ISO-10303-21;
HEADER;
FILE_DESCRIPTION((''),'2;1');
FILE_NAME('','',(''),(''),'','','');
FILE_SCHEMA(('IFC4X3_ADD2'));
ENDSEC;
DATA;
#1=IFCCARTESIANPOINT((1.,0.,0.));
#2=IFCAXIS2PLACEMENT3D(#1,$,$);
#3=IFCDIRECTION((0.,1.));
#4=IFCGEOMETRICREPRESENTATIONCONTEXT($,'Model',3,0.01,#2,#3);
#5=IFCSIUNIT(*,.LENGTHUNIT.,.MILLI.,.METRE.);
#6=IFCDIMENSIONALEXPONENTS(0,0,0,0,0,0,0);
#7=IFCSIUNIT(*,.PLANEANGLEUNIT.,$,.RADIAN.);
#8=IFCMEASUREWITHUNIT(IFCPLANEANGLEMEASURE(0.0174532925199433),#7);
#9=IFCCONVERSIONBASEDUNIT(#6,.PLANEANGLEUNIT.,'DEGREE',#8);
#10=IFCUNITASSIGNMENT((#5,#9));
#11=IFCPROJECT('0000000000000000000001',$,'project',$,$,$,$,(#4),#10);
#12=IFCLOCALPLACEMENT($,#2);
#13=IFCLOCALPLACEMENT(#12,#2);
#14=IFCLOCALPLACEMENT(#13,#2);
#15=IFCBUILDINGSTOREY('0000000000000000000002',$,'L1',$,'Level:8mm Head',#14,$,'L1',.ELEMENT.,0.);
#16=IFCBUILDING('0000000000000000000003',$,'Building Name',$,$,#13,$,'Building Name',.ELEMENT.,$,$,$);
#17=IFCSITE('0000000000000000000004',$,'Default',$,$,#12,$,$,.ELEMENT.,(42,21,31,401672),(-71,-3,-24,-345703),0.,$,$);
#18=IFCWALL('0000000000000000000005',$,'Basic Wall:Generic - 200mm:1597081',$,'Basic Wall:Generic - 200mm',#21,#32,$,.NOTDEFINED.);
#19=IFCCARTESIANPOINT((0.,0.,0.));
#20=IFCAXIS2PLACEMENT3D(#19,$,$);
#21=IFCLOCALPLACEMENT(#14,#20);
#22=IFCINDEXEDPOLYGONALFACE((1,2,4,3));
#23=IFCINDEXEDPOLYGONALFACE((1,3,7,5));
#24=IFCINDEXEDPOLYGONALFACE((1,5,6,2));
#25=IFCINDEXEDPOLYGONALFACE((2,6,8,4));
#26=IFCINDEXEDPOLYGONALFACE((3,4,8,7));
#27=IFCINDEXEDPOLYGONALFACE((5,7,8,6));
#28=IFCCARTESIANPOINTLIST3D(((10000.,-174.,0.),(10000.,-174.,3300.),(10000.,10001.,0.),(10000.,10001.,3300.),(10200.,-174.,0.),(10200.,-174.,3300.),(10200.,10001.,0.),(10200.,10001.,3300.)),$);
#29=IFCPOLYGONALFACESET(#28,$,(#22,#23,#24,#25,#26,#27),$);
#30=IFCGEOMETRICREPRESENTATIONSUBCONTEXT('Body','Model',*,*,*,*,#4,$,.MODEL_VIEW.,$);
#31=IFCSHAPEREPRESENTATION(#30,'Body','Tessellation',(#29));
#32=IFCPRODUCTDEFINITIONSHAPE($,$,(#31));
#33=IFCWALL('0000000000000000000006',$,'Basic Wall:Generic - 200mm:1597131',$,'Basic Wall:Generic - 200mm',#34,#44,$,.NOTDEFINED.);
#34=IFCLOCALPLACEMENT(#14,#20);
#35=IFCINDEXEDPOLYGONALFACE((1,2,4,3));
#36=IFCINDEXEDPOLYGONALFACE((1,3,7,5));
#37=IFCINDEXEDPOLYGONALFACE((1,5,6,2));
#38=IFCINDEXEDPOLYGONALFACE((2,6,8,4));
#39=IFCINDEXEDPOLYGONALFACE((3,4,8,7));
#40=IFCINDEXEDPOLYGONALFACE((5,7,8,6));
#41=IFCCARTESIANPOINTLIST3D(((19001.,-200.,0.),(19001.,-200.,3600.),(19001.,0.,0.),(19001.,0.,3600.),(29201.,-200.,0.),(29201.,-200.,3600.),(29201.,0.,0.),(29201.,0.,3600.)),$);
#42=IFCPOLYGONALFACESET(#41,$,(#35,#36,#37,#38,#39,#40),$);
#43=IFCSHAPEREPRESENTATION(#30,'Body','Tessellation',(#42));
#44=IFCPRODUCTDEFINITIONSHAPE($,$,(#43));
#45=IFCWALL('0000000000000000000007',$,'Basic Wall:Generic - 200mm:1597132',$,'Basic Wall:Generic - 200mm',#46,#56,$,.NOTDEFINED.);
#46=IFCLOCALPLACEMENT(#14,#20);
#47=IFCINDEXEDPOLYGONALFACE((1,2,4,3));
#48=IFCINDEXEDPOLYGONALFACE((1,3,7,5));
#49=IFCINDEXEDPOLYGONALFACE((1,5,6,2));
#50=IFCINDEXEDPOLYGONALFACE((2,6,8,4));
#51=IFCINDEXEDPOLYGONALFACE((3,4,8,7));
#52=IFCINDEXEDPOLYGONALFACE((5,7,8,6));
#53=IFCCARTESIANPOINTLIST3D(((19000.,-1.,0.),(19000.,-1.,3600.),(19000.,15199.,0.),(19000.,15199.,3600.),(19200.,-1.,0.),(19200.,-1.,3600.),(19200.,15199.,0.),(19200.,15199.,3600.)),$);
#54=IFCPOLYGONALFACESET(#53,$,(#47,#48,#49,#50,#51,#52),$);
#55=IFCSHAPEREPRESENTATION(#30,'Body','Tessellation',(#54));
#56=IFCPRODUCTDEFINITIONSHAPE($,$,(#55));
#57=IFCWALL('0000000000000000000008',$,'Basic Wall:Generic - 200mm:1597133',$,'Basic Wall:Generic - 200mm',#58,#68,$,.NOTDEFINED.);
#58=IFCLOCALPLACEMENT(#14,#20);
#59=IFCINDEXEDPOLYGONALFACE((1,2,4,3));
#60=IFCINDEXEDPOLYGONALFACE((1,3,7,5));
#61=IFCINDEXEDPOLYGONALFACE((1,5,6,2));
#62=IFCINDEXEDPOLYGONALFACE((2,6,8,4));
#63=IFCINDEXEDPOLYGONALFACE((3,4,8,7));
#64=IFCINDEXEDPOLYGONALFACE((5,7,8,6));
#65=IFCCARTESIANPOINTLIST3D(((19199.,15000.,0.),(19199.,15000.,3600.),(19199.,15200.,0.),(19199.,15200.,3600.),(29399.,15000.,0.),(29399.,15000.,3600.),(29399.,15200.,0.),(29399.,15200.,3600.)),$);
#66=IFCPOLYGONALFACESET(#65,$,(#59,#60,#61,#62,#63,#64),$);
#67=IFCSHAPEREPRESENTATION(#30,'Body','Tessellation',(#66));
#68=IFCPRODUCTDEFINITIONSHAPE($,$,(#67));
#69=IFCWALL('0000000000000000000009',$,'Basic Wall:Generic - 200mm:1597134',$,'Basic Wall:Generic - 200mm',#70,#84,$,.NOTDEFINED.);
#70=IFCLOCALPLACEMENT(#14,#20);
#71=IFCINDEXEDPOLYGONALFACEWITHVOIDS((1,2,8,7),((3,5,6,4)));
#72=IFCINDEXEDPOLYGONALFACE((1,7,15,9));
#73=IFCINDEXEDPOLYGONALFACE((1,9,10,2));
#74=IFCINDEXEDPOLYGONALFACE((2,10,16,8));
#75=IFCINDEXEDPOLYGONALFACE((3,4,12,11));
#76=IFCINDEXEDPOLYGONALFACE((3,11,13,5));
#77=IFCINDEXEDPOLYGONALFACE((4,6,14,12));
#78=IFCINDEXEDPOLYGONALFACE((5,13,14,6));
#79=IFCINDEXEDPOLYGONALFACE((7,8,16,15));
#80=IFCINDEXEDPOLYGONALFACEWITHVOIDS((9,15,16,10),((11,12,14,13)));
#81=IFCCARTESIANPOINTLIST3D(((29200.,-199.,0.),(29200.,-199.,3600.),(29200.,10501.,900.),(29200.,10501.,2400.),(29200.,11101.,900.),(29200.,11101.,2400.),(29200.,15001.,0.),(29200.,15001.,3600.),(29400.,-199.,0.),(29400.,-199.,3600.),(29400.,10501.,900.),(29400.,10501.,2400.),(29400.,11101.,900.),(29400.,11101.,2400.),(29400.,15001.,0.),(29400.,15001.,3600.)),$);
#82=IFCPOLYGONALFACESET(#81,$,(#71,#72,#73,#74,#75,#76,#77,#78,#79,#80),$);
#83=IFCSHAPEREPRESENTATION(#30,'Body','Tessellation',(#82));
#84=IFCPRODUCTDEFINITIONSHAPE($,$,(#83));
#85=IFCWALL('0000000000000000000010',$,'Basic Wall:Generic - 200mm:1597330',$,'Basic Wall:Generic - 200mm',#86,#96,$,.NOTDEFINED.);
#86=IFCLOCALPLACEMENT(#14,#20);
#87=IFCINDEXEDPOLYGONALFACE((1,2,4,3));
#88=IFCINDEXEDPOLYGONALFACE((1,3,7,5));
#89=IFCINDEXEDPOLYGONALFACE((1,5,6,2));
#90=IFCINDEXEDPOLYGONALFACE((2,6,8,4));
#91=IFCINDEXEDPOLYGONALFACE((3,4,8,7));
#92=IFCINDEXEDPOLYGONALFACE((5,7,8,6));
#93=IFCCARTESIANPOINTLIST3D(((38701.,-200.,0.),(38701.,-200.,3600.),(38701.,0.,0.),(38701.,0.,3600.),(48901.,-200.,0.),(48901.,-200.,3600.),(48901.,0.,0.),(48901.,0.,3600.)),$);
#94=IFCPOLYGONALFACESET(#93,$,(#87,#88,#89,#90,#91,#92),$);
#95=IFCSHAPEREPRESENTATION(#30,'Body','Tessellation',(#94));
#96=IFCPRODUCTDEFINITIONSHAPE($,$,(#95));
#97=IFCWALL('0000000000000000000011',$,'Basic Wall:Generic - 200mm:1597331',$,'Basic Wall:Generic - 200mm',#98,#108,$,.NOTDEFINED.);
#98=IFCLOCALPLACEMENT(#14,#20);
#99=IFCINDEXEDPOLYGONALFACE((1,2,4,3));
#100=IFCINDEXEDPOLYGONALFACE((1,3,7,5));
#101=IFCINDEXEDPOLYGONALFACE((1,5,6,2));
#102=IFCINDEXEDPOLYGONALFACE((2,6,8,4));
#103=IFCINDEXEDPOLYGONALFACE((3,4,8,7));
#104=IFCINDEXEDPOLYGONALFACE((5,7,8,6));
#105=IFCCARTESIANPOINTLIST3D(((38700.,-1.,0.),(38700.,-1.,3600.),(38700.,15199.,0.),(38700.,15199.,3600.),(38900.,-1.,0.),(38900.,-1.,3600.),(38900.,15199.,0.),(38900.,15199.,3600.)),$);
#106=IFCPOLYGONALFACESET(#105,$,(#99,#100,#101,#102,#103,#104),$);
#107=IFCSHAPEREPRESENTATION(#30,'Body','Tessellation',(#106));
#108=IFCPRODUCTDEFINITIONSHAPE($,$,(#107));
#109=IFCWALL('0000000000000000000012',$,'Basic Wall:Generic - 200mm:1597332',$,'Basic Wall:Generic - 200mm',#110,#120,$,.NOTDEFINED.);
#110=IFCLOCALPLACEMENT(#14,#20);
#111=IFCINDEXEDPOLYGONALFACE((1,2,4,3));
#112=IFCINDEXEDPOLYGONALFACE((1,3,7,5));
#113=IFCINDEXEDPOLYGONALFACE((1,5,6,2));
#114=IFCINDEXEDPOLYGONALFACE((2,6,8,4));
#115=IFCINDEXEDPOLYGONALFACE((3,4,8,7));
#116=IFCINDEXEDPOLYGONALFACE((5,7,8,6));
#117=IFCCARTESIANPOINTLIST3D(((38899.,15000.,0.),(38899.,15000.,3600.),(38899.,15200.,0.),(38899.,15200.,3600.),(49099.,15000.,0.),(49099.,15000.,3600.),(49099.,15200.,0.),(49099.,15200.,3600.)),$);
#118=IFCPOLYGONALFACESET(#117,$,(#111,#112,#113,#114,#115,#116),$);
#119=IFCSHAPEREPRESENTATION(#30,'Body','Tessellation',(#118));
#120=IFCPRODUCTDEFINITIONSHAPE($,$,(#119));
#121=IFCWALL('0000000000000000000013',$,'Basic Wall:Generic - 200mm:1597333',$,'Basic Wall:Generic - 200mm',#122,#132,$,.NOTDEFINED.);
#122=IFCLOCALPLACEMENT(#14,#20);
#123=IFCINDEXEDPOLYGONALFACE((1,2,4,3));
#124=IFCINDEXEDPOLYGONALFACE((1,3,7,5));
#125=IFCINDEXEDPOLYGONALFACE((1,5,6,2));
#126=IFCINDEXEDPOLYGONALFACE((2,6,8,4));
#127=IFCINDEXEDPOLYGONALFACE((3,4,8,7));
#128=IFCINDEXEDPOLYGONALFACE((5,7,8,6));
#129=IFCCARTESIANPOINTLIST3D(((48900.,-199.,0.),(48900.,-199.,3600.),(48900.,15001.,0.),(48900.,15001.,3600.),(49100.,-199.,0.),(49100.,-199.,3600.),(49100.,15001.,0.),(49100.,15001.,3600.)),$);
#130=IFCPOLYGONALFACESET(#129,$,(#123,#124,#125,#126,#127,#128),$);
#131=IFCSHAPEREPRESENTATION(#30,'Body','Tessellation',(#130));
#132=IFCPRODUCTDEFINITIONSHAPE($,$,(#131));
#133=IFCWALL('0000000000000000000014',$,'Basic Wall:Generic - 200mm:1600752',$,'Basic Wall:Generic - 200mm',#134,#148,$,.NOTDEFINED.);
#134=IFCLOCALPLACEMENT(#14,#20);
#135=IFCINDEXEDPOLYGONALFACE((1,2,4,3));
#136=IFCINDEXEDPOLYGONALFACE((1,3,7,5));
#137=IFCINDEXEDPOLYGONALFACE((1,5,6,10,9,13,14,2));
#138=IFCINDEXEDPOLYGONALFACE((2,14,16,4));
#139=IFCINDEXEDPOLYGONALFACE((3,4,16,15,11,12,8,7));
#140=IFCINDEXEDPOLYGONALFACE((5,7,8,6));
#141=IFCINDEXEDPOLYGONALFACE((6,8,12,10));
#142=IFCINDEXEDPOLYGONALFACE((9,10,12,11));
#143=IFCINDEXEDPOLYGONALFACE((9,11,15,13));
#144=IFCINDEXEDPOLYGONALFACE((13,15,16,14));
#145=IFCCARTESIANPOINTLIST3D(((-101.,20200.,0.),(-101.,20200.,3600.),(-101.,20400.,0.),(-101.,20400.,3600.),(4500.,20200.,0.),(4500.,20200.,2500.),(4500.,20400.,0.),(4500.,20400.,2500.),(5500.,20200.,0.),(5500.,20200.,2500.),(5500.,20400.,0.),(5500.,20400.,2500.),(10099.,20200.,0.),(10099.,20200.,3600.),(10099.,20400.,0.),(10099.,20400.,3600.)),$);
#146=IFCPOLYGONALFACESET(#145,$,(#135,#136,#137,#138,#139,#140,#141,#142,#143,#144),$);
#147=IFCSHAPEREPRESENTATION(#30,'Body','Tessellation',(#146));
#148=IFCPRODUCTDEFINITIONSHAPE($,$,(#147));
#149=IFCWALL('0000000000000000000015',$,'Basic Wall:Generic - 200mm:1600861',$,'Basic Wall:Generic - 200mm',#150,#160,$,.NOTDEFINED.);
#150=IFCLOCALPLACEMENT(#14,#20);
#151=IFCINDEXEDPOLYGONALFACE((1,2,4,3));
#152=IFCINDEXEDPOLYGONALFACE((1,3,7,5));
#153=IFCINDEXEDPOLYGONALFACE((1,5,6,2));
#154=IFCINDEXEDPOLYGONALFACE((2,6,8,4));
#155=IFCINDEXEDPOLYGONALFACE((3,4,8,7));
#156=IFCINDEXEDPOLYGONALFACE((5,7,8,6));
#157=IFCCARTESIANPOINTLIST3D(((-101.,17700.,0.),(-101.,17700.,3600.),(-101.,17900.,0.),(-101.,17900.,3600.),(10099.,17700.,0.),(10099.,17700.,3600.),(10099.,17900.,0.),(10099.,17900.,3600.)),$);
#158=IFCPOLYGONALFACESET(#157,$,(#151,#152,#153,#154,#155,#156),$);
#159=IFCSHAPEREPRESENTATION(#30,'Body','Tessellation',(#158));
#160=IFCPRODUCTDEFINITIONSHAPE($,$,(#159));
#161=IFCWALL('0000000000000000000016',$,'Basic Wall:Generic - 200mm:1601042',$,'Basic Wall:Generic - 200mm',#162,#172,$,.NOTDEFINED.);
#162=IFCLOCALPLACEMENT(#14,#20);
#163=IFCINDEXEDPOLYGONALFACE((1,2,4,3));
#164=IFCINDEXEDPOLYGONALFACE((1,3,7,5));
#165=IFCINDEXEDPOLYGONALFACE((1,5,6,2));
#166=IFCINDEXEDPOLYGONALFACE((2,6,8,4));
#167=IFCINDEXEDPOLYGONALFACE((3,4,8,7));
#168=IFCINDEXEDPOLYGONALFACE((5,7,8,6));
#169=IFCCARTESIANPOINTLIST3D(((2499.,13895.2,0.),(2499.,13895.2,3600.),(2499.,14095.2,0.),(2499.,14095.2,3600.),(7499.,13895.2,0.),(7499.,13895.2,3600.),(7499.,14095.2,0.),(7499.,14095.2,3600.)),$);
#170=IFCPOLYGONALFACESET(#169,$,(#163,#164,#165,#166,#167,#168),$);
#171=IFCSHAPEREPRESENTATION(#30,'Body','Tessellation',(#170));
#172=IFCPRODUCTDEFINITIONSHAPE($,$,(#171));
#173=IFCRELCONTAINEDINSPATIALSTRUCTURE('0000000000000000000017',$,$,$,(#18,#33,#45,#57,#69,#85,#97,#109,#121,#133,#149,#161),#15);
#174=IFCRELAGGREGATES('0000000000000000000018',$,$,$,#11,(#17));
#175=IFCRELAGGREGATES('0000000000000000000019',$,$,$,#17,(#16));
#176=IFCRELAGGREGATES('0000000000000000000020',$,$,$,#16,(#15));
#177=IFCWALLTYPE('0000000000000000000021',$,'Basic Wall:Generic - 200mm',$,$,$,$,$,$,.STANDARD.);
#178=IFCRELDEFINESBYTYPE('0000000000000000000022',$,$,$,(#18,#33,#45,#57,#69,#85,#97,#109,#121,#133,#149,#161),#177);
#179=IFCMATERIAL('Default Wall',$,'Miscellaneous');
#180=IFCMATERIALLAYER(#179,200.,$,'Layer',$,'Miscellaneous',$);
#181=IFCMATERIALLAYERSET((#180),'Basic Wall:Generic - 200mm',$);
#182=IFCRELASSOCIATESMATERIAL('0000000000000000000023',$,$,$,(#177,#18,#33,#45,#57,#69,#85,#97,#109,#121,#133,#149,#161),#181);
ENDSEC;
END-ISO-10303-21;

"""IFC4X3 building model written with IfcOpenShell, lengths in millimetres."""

from ifc_helpers import new_model, entity, si_unit, converted_unit, direction, frame, frame_2d, origin_2d_with_axis, place, context, subcontext, project, spatial, rectangle, extrude, material, layer, layer_set, type_object, element, save


model = new_model("IFC4X3")

# Units and contexts
model_context = context("Model", 3, precision=0.01, world=frame((1.0, 0.0, 0.0)), true_north=direction((0.0, 1.0)))
body_context = subcontext(model_context, "Body", "Model", "MODEL_VIEW")
ifc_project = project(units=[si_unit("LENGTHUNIT", "METRE", prefix="MILLI"), converted_unit("PLANEANGLEUNIT", "DEGREE", entity("IfcPlaneAngleMeasure", 0.0174532925199433), si_unit("PLANEANGLEUNIT", "RADIAN"), dimensions=[0, 0, 0, 0, 0, 0, 0])], contexts=[model_context])

# Site, building, storey
site_placement = place(None, frame((1.0, 0.0, 0.0)))
site = spatial("IfcSite", under=ifc_project, at=site_placement, Name="Default", CompositionType="ELEMENT", RefLatitude=(42, 21, 31, 401672), RefLongitude=(-71, -3, -24, -345703), RefElevation=0.0)
building_placement = place(site_placement, frame((1.0, 0.0, 0.0)))
building = spatial("IfcBuilding", under=site, at=building_placement, Name="Building Name", LongName="Building Name", CompositionType="ELEMENT")
storey_placement = place(building_placement, frame((1.0, 0.0, 0.0)))
storey = spatial("IfcBuildingStorey", under=building, at=storey_placement, Name="L1", ObjectType="Level:8mm Head", LongName="L1", CompositionType="ELEMENT", Elevation=0.0)

# Walls
ifc_material_1 = material(Name="Default Wall", Category="Miscellaneous")
ifc_layer_1 = layer(ifc_material_1, 200.0, Name="Layer", Category="Miscellaneous")
ifc_layer_set_1 = layer_set([ifc_layer_1], Name="Basic Wall:Generic - 200mm")
wall_type_1 = type_object("IfcWallType", Name="Basic Wall:Generic - 200mm", PredefinedType="STANDARD", material=ifc_layer_set_1)
wall_1_placement = place(storey_placement, frame((10100.0, -175.0, 0.0), z_axis=(0.0, 0.0, 1.0), x_axis=(0.0, 1.0, 0.0)))
element("IfcWall", 1, at=wall_1_placement, inside=storey, type_object=wall_type_1, material=ifc_layer_set_1, Name="Basic Wall:Generic - 200mm:1597081", ObjectType="Basic Wall:Generic - 200mm", PredefinedType="NOTDEFINED", context=body_context, shape_type="SweptSolid", body=[
    extrude(rectangle(XDim=10175.0, YDim=200.0, at=frame_2d((5087.5, 0.0), x_axis=(-1.0, 0.0))), frame((1.0, 0.0, 0.0)), (0.0, 0.0, 1.0), 3300.0),
])
wall_2_placement = place(storey_placement, frame((19000.0, -100.0, 0.0)))
element("IfcWall", 2, at=wall_2_placement, inside=storey, type_object=wall_type_1, material=ifc_layer_set_1, Name="Basic Wall:Generic - 200mm:1597131", ObjectType="Basic Wall:Generic - 200mm", PredefinedType="NOTDEFINED", context=body_context, shape_type="SweptSolid", body=[
    extrude(rectangle(XDim=10200.0, YDim=200.0, at=frame_2d((5100.0, 0.0), x_axis=(-1.0, 0.0))), frame((1.0, 0.0, 0.0)), (0.0, 0.0, 1.0), 3600.0),
])
wall_3_placement = place(storey_placement, frame((19100.0, 15200.0, 0.0), z_axis=(0.0, 0.0, 1.0), x_axis=(0.0, -1.0, 0.0)))
element("IfcWall", 3, at=wall_3_placement, inside=storey, type_object=wall_type_1, material=ifc_layer_set_1, Name="Basic Wall:Generic - 200mm:1597132", ObjectType="Basic Wall:Generic - 200mm", PredefinedType="NOTDEFINED", context=body_context, shape_type="SweptSolid", body=[
    extrude(rectangle(XDim=15200.0, YDim=200.0, at=frame_2d((7600.0, 0.0), x_axis=(-1.0, 0.0))), frame((1.0, 0.0, 0.0)), (0.0, 0.0, 1.0), 3600.0),
])
wall_4_placement = place(storey_placement, frame((29400.0, 15100.0, 0.0), z_axis=(0.0, 0.0, 1.0), x_axis=(-1.0, 0.0, 0.0)))
element("IfcWall", 4, at=wall_4_placement, inside=storey, type_object=wall_type_1, material=ifc_layer_set_1, Name="Basic Wall:Generic - 200mm:1597133", ObjectType="Basic Wall:Generic - 200mm", PredefinedType="NOTDEFINED", context=body_context, shape_type="SweptSolid", body=[
    extrude(rectangle(XDim=10200.0, YDim=200.0, at=frame_2d((5100.0, 0.0), x_axis=(-1.0, 0.0))), frame((1.0, 0.0, 0.0)), (0.0, 0.0, 1.0), 3600.0),
])

# Wall, opening
wall_5_placement = place(storey_placement, frame((29300.0, -200.0, 0.0), z_axis=(0.0, 0.0, 1.0), x_axis=(0.0, 1.0, 0.0)))
wall_5 = element("IfcWall", 5, at=wall_5_placement, inside=storey, type_object=wall_type_1, material=ifc_layer_set_1, Name="Basic Wall:Generic - 200mm:1597134", ObjectType="Basic Wall:Generic - 200mm", PredefinedType="NOTDEFINED", context=body_context, shape_type="SweptSolid", body=[
    extrude(rectangle(XDim=15200.0, YDim=200.0, at=frame_2d((7600.0, 0.0), x_axis=(-1.0, 0.0))), frame((1.0, 0.0, 0.0)), (0.0, 0.0, 1.0), 3600.0),
])
opening_1_placement = place(wall_5_placement, frame((11300.0, 100.0, 900.0)))
element("IfcOpeningElement", 6, at=opening_1_placement, cuts=wall_5, PredefinedType="OPENING", context=body_context, shape_type="SweptSolid", body=[
    extrude(rectangle(XDim=1500.0, YDim=600.0, at=frame_2d((750.0, 300.0), x_axis=(-1.0, 0.0))), frame((1.0, 0.0, 0.0), z_axis=(0.0, -1.0, 0.0), x_axis=(0.0, 0.0, 1.0)), (0.0, 0.0, 1.0), 200.0),
])

# Walls
wall_6_placement = place(storey_placement, frame((38700.0, -100.0, 0.0)))
element("IfcWall", 7, at=wall_6_placement, inside=storey, type_object=wall_type_1, material=ifc_layer_set_1, Name="Basic Wall:Generic - 200mm:1597330", ObjectType="Basic Wall:Generic - 200mm", PredefinedType="NOTDEFINED", context=body_context, shape_type="SweptSolid", body=[
    extrude(rectangle(XDim=10200.0, YDim=200.0, at=frame_2d((5100.0, 0.0), x_axis=(-1.0, 0.0))), frame((1.0, 0.0, 0.0)), (0.0, 0.0, 1.0), 3600.0),
])
wall_7_placement = place(storey_placement, frame((38800.0, 15200.0, 0.0), z_axis=(0.0, 0.0, 1.0), x_axis=(0.0, -1.0, 0.0)))
element("IfcWall", 8, at=wall_7_placement, inside=storey, type_object=wall_type_1, material=ifc_layer_set_1, Name="Basic Wall:Generic - 200mm:1597331", ObjectType="Basic Wall:Generic - 200mm", PredefinedType="NOTDEFINED", context=body_context, shape_type="SweptSolid", body=[
    extrude(rectangle(XDim=15200.0, YDim=200.0, at=frame_2d((7600.0, 0.0), x_axis=(-1.0, 0.0))), frame((1.0, 0.0, 0.0)), (0.0, 0.0, 1.0), 3600.0),
])
wall_8_placement = place(storey_placement, frame((49100.0, 15100.0, 0.0), z_axis=(0.0, 0.0, 1.0), x_axis=(-1.0, 0.0, 0.0)))
element("IfcWall", 9, at=wall_8_placement, inside=storey, type_object=wall_type_1, material=ifc_layer_set_1, Name="Basic Wall:Generic - 200mm:1597332", ObjectType="Basic Wall:Generic - 200mm", PredefinedType="NOTDEFINED", context=body_context, shape_type="SweptSolid", body=[
    extrude(rectangle(XDim=10200.0, YDim=200.0, at=frame_2d((5100.0, 0.0), x_axis=(-1.0, 0.0))), frame((1.0, 0.0, 0.0)), (0.0, 0.0, 1.0), 3600.0),
])
wall_9_placement = place(storey_placement, frame((49000.0, -200.0, 0.0), z_axis=(0.0, 0.0, 1.0), x_axis=(0.0, 1.0, 0.0)))
element("IfcWall", 10, at=wall_9_placement, inside=storey, type_object=wall_type_1, material=ifc_layer_set_1, Name="Basic Wall:Generic - 200mm:1597333", ObjectType="Basic Wall:Generic - 200mm", PredefinedType="NOTDEFINED", context=body_context, shape_type="SweptSolid", body=[
    extrude(rectangle(XDim=15200.0, YDim=200.0, at=frame_2d((7600.0, 0.0), x_axis=(-1.0, 0.0))), frame((1.0, 0.0, 0.0)), (0.0, 0.0, 1.0), 3600.0),
])

# Wall, opening
wall_10_placement = place(storey_placement, frame((10100.0, 20300.0, 0.0), z_axis=(0.0, 0.0, 1.0), x_axis=(-1.0, 0.0, 0.0)))
wall_10 = element("IfcWall", 11, at=wall_10_placement, inside=storey, type_object=wall_type_1, material=ifc_layer_set_1, Name="Basic Wall:Generic - 200mm:1600752", ObjectType="Basic Wall:Generic - 200mm", PredefinedType="NOTDEFINED", context=body_context, shape_type="SweptSolid", body=[
    extrude(rectangle(XDim=10200.0, YDim=200.0, at=frame_2d((5100.0, 0.0), x_axis=(1.0, 0.0))), frame((1.0, 0.0, 0.0)), (0.0, 0.0, 1.0), 3600.0),
])
opening_2_placement = place(wall_10_placement, frame((5600.0, 100.0, 0.0)))
element("IfcOpeningElement", 12, at=opening_2_placement, cuts=wall_10, PredefinedType="OPENING", context=body_context, shape_type="SweptSolid", body=[
    extrude(rectangle(XDim=2500.0, YDim=1000.0, at=origin_2d_with_axis()), frame((-500.0, -200.0, 1250.0), z_axis=(0.0, 1.0, 0.0), x_axis=(0.0, 0.0, -1.0)), (0.0, 0.0, 1.0), 200.0),
])

# Walls
wall_11_placement = place(storey_placement, frame((10100.0, 17800.0, 0.0), z_axis=(0.0, 0.0, 1.0), x_axis=(-1.0, 0.0, 0.0)))
element("IfcWall", 13, at=wall_11_placement, inside=storey, type_object=wall_type_1, material=ifc_layer_set_1, Name="Basic Wall:Generic - 200mm:1600861", ObjectType="Basic Wall:Generic - 200mm", PredefinedType="NOTDEFINED", context=body_context, shape_type="SweptSolid", body=[
    extrude(rectangle(XDim=10200.0, YDim=200.0, at=frame_2d((5100.0, 0.0), x_axis=(-1.0, 0.0))), frame((1.0, 0.0, 0.0)), (0.0, 0.0, 1.0), 3600.0),
])
wall_12_placement = place(storey_placement, frame((7500.0, 13995.2, 0.0), z_axis=(0.0, 0.0, 1.0), x_axis=(-1.0, 0.0, 0.0)))
element("IfcWall", 14, at=wall_12_placement, inside=storey, type_object=wall_type_1, material=ifc_layer_set_1, Name="Basic Wall:Generic - 200mm:1601042", ObjectType="Basic Wall:Generic - 200mm", PredefinedType="NOTDEFINED", context=body_context, shape_type="SweptSolid", body=[
    extrude(rectangle(XDim=5000.0, YDim=200.0, at=frame_2d((2500.0, 0.0), x_axis=(-1.0, 0.0))), frame((1.0, 0.0, 0.0)), (0.0, 0.0, 1.0), 3600.0),
])

save(model, "model.ifc")
